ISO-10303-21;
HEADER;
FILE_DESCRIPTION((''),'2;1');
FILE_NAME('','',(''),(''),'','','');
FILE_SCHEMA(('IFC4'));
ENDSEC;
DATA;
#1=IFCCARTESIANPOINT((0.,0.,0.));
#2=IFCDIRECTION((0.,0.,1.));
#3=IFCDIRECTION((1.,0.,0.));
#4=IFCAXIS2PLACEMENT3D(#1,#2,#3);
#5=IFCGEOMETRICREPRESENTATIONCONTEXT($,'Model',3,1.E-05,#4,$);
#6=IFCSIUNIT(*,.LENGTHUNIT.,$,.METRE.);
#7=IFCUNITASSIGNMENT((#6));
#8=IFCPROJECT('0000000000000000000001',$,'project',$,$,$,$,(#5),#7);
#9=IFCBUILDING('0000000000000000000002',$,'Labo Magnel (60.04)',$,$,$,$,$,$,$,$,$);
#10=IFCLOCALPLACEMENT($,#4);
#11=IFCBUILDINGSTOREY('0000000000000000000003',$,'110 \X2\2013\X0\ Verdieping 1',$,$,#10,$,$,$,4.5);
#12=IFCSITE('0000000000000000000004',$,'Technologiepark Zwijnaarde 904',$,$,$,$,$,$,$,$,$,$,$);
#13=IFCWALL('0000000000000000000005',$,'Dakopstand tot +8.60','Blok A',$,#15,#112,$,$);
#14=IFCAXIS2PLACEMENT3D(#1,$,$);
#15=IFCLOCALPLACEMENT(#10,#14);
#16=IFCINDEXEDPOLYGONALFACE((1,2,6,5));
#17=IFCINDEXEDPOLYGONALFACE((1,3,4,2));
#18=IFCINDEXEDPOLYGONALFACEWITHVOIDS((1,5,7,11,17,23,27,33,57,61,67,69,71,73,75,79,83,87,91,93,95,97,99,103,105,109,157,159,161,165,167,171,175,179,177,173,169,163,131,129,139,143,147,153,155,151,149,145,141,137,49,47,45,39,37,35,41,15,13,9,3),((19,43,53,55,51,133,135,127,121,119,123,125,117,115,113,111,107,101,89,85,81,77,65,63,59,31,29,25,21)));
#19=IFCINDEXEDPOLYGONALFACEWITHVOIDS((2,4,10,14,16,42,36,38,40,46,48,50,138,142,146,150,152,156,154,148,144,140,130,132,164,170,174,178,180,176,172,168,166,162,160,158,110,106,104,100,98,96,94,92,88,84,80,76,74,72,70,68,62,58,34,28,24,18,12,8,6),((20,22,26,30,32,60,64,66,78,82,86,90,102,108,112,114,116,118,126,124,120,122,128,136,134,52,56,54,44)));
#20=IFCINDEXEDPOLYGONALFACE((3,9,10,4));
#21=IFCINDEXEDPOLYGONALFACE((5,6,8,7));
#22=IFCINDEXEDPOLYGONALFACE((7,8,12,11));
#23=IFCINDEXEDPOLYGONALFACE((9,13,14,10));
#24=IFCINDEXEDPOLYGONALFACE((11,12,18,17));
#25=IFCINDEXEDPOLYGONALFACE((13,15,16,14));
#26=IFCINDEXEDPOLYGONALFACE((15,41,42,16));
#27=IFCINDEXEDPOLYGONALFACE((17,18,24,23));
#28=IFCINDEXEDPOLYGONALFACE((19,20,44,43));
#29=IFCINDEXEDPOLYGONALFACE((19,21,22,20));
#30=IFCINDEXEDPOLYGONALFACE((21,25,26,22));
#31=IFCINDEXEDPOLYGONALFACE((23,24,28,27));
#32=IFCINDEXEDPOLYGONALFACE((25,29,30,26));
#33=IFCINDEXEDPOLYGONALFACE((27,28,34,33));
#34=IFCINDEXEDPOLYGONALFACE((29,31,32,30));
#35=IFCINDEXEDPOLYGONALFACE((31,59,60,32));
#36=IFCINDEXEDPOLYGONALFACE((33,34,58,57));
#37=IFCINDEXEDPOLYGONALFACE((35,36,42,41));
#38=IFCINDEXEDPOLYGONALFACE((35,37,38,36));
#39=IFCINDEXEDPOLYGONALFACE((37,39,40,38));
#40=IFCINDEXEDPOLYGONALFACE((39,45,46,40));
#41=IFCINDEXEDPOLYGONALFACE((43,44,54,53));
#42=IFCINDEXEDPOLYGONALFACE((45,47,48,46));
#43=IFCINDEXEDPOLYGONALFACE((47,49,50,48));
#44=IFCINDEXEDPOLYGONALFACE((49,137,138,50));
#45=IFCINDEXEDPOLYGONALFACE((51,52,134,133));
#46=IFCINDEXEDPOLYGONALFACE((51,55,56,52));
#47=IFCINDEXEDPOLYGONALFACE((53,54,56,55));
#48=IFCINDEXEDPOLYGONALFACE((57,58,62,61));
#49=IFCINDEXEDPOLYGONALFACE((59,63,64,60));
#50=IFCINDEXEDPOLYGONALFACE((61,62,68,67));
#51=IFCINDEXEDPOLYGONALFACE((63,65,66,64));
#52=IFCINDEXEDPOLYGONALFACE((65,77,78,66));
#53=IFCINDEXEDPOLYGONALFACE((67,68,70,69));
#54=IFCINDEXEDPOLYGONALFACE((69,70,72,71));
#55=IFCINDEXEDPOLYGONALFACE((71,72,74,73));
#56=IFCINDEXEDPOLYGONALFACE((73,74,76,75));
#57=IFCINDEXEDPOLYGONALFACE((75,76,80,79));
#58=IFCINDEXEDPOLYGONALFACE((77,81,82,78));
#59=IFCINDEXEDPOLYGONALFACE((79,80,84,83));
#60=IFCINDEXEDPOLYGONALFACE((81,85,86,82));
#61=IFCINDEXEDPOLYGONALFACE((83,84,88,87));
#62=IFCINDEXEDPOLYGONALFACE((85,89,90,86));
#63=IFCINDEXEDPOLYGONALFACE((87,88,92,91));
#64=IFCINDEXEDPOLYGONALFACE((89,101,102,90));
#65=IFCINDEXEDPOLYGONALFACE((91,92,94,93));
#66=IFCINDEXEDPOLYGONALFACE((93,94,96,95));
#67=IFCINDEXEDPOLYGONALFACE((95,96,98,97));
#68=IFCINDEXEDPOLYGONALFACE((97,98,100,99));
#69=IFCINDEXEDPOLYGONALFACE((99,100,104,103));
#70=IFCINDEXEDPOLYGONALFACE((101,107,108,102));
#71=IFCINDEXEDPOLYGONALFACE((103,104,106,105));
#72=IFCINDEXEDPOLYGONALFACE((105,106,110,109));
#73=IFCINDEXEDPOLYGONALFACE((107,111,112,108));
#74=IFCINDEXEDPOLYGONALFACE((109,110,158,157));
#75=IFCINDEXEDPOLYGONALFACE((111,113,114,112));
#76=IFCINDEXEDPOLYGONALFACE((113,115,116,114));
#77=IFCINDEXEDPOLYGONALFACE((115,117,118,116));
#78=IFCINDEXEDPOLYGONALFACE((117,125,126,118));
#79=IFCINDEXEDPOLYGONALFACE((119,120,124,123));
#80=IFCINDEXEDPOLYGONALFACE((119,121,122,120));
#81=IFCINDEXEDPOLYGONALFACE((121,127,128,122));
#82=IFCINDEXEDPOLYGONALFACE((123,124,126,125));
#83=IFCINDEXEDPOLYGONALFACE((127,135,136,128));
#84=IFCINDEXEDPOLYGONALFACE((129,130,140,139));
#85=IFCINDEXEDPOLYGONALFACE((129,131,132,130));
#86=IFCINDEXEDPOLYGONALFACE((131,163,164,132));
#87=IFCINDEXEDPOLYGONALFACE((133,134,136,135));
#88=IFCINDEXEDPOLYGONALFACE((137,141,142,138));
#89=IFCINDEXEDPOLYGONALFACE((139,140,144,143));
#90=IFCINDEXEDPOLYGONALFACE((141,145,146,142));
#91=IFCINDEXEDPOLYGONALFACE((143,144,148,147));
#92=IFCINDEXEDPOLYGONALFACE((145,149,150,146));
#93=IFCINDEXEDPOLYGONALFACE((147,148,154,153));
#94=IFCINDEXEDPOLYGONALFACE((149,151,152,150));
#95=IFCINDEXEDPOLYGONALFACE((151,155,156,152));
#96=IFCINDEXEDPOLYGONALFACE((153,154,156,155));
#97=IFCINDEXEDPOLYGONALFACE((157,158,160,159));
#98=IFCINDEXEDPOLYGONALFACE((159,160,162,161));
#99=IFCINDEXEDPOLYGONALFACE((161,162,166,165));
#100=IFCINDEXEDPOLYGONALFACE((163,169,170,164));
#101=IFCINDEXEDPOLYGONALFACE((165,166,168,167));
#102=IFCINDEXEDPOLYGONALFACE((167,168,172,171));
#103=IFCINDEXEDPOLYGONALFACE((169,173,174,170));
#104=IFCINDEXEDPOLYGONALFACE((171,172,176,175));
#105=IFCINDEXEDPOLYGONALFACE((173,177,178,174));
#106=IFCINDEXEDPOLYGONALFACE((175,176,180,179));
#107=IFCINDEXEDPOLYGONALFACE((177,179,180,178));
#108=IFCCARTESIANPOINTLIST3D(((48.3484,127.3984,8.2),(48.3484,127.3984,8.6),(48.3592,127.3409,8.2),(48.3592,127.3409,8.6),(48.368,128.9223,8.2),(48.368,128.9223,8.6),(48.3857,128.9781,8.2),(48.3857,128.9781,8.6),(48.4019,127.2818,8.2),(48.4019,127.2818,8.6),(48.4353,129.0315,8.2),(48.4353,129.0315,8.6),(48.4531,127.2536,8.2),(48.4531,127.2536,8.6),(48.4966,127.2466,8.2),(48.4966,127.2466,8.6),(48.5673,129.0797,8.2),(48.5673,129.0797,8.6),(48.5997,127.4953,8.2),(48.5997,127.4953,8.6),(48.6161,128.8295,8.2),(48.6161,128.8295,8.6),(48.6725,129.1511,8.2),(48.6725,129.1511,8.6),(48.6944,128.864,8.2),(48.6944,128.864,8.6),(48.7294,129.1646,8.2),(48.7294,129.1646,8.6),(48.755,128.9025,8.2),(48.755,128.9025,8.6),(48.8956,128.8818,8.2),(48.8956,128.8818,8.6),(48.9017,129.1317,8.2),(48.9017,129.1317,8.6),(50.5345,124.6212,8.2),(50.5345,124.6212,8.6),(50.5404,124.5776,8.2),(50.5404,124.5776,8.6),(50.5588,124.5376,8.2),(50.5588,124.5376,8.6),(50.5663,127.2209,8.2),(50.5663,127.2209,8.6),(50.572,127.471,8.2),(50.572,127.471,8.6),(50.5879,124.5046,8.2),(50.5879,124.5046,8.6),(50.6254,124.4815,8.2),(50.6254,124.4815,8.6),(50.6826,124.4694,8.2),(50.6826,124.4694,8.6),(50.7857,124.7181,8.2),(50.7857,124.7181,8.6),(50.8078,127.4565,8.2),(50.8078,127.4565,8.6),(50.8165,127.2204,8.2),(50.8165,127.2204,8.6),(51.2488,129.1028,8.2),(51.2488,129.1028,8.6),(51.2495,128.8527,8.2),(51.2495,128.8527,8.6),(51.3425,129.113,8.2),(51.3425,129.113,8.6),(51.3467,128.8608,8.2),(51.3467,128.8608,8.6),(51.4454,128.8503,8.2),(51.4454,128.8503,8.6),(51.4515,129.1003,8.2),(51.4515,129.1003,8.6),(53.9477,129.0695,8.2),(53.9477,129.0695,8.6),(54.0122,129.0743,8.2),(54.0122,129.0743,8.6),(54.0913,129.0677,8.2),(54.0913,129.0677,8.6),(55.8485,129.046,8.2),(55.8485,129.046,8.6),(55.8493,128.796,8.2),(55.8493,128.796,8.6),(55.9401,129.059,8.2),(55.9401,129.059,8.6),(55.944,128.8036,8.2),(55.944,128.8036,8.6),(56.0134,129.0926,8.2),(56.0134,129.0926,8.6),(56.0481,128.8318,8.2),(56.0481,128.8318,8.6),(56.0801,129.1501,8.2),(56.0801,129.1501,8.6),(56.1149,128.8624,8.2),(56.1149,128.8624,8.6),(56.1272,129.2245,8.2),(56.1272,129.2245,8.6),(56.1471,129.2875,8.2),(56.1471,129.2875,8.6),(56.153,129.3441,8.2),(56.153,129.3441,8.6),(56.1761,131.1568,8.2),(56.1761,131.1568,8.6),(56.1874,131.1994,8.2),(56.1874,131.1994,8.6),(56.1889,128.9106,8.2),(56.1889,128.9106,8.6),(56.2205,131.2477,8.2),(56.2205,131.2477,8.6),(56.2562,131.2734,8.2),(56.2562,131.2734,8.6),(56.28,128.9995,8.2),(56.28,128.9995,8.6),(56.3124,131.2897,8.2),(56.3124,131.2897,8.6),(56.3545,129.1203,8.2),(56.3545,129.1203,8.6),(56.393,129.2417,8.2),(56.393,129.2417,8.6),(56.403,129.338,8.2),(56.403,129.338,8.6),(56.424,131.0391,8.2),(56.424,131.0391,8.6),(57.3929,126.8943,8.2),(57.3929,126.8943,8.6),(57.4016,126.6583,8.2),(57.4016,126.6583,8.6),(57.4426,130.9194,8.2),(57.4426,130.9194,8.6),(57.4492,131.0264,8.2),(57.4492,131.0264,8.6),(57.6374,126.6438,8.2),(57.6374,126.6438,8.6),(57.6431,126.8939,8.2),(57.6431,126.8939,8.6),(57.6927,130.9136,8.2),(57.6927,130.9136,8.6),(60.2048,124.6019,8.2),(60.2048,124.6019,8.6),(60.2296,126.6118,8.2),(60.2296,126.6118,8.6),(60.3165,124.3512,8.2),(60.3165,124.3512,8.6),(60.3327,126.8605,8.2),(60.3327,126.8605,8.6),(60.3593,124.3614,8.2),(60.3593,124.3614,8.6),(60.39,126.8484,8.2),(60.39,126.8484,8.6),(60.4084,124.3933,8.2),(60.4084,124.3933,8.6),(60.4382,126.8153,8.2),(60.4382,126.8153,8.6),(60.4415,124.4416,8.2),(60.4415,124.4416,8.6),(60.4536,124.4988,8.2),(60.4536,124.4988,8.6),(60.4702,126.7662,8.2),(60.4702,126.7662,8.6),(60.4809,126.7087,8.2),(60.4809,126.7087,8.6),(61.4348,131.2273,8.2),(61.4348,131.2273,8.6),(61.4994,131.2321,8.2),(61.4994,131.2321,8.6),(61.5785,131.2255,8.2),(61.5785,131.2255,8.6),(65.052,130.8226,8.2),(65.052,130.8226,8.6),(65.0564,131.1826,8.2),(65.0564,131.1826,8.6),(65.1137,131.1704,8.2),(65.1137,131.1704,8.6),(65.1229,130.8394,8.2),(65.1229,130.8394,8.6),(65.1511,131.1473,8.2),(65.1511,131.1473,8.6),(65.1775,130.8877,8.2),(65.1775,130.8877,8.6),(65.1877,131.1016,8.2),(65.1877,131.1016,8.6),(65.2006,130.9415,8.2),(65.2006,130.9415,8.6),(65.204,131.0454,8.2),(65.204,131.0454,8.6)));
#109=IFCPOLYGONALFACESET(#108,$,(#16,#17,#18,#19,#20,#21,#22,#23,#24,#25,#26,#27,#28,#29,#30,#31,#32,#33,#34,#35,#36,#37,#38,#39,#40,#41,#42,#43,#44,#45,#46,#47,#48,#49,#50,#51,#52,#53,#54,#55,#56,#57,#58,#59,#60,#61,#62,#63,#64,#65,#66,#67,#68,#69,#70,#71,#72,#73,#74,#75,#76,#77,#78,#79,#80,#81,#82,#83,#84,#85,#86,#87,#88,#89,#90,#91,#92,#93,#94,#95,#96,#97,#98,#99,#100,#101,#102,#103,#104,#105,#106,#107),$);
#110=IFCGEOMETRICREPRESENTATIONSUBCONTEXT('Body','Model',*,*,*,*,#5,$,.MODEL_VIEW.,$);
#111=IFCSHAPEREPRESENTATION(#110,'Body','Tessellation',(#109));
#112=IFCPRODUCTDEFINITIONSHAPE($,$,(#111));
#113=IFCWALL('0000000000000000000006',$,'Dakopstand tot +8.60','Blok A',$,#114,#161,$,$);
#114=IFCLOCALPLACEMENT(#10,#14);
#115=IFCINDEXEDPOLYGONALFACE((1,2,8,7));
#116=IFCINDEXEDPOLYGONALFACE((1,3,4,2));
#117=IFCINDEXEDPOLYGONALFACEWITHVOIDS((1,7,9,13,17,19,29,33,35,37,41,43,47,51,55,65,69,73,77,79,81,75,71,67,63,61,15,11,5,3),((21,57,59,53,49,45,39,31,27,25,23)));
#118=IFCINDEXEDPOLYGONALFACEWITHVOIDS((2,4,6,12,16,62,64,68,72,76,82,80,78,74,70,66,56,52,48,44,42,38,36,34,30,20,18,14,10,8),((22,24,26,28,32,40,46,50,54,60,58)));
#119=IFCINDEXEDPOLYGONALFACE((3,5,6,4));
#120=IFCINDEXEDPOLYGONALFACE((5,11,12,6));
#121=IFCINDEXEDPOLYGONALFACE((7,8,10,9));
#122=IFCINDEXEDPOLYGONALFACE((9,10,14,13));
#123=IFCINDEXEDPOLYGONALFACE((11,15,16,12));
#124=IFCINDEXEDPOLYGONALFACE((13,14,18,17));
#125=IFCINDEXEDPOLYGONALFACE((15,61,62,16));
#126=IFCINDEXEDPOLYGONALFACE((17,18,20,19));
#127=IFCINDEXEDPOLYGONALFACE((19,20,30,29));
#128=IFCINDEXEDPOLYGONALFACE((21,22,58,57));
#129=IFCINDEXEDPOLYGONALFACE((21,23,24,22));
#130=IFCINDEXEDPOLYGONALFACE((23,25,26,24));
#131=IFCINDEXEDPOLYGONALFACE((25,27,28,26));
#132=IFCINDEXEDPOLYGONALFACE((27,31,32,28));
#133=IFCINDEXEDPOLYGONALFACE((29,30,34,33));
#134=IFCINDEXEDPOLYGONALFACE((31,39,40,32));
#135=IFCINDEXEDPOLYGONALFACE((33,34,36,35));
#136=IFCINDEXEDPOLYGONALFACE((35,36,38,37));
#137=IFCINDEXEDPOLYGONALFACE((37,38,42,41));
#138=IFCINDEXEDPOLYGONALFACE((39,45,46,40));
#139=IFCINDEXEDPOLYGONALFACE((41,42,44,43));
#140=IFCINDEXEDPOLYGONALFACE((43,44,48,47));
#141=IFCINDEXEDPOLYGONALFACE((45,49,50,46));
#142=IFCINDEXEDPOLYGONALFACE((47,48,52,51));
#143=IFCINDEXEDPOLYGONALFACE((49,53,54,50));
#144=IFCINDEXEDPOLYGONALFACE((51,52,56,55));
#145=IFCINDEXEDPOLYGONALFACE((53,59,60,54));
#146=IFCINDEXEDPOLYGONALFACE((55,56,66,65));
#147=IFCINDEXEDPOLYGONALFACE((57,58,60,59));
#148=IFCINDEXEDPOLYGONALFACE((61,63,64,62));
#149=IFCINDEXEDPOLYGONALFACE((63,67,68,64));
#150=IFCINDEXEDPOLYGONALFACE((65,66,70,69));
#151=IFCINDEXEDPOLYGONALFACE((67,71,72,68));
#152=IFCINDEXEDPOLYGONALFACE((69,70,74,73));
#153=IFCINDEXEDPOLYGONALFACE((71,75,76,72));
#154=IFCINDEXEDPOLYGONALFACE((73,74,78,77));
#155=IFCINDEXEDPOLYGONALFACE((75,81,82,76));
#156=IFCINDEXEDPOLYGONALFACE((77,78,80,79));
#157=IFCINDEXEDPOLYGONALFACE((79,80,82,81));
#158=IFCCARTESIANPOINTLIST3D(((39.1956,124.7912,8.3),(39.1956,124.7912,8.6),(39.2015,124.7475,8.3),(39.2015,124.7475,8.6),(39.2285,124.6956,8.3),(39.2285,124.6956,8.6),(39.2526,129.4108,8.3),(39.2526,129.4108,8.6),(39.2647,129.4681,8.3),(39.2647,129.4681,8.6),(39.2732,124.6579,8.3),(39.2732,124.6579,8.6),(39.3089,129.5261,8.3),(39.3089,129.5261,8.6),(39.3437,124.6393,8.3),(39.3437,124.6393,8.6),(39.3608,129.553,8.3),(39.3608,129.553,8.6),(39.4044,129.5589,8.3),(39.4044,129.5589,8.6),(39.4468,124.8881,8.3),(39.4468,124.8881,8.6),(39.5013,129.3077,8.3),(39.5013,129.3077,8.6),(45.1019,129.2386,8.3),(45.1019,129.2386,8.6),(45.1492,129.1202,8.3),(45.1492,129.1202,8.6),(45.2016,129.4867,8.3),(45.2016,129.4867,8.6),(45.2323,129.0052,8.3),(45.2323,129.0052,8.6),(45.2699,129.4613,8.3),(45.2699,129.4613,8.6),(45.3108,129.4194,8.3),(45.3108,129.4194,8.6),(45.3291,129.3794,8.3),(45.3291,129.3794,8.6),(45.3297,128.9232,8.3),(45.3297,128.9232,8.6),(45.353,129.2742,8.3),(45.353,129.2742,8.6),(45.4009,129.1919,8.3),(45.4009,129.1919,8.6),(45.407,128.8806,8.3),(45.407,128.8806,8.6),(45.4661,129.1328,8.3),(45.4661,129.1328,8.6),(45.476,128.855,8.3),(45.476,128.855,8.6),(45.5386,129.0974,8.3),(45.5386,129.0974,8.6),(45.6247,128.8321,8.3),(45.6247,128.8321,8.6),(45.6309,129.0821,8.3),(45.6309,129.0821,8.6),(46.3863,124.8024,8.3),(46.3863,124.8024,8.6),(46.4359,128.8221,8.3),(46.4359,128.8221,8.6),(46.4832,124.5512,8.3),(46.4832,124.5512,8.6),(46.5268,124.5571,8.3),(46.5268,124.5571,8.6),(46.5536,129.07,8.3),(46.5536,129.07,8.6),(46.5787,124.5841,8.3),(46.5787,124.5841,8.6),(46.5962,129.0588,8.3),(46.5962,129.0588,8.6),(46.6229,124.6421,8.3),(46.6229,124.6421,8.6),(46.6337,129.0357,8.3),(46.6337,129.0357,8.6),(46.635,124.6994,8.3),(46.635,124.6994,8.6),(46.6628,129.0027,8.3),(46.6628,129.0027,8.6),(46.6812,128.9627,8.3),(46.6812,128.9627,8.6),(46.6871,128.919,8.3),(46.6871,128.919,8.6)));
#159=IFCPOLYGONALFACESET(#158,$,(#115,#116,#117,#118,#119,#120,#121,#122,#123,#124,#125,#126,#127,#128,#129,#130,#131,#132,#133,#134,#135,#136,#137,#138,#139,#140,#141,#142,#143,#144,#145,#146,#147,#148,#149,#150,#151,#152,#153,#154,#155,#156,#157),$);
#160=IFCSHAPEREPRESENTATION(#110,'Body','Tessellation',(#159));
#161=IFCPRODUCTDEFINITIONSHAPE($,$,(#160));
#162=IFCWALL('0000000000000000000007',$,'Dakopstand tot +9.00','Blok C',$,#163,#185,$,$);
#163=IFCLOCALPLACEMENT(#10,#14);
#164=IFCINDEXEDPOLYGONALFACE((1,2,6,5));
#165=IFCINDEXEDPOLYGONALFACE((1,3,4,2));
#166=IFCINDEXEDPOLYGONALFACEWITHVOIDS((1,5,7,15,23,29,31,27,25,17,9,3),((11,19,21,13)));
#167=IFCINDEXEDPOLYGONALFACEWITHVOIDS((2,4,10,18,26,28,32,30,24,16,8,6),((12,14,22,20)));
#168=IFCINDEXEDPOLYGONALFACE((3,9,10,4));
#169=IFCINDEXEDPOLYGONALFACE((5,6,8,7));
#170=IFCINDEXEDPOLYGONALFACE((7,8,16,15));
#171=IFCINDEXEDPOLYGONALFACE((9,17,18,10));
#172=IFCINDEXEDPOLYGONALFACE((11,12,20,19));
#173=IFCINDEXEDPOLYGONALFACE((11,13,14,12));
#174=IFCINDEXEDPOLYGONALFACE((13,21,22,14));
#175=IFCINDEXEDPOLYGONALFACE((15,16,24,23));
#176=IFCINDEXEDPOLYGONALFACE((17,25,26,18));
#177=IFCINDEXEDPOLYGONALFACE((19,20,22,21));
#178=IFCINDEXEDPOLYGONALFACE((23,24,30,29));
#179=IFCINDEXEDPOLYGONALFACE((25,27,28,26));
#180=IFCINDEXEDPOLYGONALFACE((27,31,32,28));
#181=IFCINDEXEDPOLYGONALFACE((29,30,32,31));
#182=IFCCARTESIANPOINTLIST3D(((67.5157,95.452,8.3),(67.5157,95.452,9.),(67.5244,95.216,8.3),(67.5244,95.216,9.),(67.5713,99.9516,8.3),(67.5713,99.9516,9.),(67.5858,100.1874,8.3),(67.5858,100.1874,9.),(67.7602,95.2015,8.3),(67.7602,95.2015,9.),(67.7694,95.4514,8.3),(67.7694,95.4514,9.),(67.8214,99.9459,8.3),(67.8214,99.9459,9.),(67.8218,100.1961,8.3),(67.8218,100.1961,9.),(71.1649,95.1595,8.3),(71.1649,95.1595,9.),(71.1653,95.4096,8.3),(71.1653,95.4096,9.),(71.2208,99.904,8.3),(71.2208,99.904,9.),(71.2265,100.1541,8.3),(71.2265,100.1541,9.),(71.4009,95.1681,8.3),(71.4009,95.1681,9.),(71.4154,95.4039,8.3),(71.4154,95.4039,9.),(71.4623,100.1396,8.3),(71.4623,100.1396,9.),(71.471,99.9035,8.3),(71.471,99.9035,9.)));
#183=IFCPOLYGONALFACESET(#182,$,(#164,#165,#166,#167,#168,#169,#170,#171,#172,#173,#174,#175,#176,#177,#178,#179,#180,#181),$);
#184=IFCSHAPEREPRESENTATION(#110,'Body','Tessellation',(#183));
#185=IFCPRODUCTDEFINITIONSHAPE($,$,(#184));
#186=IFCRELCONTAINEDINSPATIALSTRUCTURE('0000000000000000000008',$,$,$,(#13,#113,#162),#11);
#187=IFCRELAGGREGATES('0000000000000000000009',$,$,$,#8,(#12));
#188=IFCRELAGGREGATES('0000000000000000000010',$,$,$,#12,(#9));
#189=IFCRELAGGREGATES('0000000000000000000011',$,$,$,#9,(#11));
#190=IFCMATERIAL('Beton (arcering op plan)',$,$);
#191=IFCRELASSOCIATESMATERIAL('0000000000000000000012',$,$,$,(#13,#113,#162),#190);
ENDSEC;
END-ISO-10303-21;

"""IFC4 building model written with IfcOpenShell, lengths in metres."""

from ifc_helpers import new_model, si_unit, frame, origin, origin_with_axes, place, context, subcontext, project, spatial, polyline, outline, extrude, material, element, save


model = new_model("IFC4")

# Units and contexts
model_context = context("Model", 3, precision=1e-05, world=origin_with_axes())
body_context = subcontext(model_context, "Body", "Model", "MODEL_VIEW")
ifc_project = project(units=[si_unit("LENGTHUNIT", "METRE")], contexts=[model_context])

# Site, building, storey
site = spatial("IfcSite", under=ifc_project, Name="Technologiepark Zwijnaarde 904")
building = spatial("IfcBuilding", under=site, Name="Labo Magnel (60.04)")
storey_placement = place(None, origin_with_axes())
storey = spatial("IfcBuildingStorey", under=building, at=storey_placement, Name="110 – Verdieping 1", Elevation=4.5)

# Shared definitions
ifc_material_1 = material(Name="Beton (arcering op plan)")

# Walls
wall_1_placement = place(storey_placement, frame((0.0, 0.0, 8.2), z_axis=(0.0, 0.0, 1.0), x_axis=(1.0, 0.0, 0.0)))
element("IfcWall", 1, at=wall_1_placement, inside=storey, material=ifc_material_1, Name="Dakopstand tot +8.60", Description="Blok A", context=body_context, shape_type="SweptSolid", body=[
    extrude(outline(polyline([(48.368, 128.9223), (48.3857, 128.9781), (48.4353, 129.0315), (48.5673, 129.0797), (48.6725, 129.1511), (48.7294, 129.1646), (48.9017, 129.1317), (51.2488, 129.1028), (51.3425, 129.113), (51.4515, 129.1003), (53.9477, 129.0695), (54.0122, 129.0743), (54.0913, 129.0677), (55.8485, 129.046), (55.9401, 129.059), (56.0134, 129.0926), (56.0801, 129.1501), (56.1272, 129.2245), (56.1471, 129.2875), (56.153, 129.3441), (56.1761, 131.1568), (56.1874, 131.1994), (56.2205, 131.2477), (56.2562, 131.2734), (56.3124, 131.2897), (61.4348, 131.2273), (61.4994, 131.2321), (61.5785, 131.2255), (65.0564, 131.1826), (65.1137, 131.1704), (65.1511, 131.1473), (65.1877, 131.1016), (65.204, 131.0454), (65.2006, 130.9415), (65.1775, 130.8877), (65.1229, 130.8394), (65.052, 130.8226), (57.6927, 130.9136), (57.6431, 126.8939), (60.3327, 126.8605), (60.39, 126.8484), (60.4382, 126.8153), (60.4702, 126.7662), (60.4809, 126.7087), (60.4536, 124.4988), (60.4415, 124.4416), (60.4084, 124.3933), (60.3593, 124.3614), (60.3165, 124.3512), (50.6826, 124.4694), (50.6254, 124.4815), (50.5879, 124.5046), (50.5588, 124.5376), (50.5404, 124.5776), (50.5345, 124.6212), (50.5663, 127.2209), (48.4966, 127.2466), (48.4531, 127.2536), (48.4019, 127.2818), (48.3592, 127.3409), (48.3484, 127.3984), (48.368, 128.9223)]), holes=[polyline([(48.5997, 127.4953), (50.572, 127.471), (50.8078, 127.4565), (50.8165, 127.2204), (50.7857, 124.7181), (60.2048, 124.6019), (60.2296, 126.6118), (57.6374, 126.6438), (57.4016, 126.6583), (57.3929, 126.8943), (57.4426, 130.9194), (57.4492, 131.0264), (56.424, 131.0391), (56.403, 129.338), (56.393, 129.2417), (56.3545, 129.1203), (56.28, 128.9995), (56.1889, 128.9106), (56.1149, 128.8624), (56.0481, 128.8318), (55.944, 128.8036), (55.8493, 128.796), (51.4454, 128.8503), (51.3467, 128.8608), (51.2495, 128.8527), (48.8956, 128.8818), (48.755, 128.9025), (48.6944, 128.864), (48.6161, 128.8295), (48.5997, 127.4953)])]), origin(), (0.0, 0.0, 1.0), 0.4),
])
wall_2_placement = place(storey_placement, frame((0.0, 0.0, 8.3), z_axis=(0.0, 0.0, 1.0), x_axis=(1.0, 0.0, 0.0)))
element("IfcWall", 2, at=wall_2_placement, inside=storey, material=ifc_material_1, Name="Dakopstand tot +8.60", Description="Blok A", context=body_context, shape_type="SweptSolid", body=[
    extrude(outline(polyline([(45.2016, 129.4867), (45.2699, 129.4613), (45.3108, 129.4194), (45.3291, 129.3794), (45.353, 129.2742), (45.4009, 129.1919), (45.4661, 129.1328), (45.5386, 129.0974), (45.6309, 129.0821), (46.5536, 129.07), (46.5962, 129.0588), (46.6337, 129.0357), (46.6628, 129.0027), (46.6812, 128.9627), (46.6871, 128.919), (46.635, 124.6994), (46.6229, 124.6421), (46.5787, 124.5841), (46.5268, 124.5571), (46.4832, 124.5512), (39.3437, 124.6393), (39.2732, 124.6579), (39.2285, 124.6956), (39.2015, 124.7475), (39.1956, 124.7912), (39.2526, 129.4108), (39.2647, 129.4681), (39.3089, 129.5261), (39.3608, 129.553), (39.4044, 129.5589), (45.2016, 129.4867)]), holes=[polyline([(46.3863, 124.8024), (46.4359, 128.8221), (45.6247, 128.8321), (45.476, 128.855), (45.407, 128.8806), (45.3297, 128.9232), (45.2323, 129.0052), (45.1492, 129.1202), (45.1019, 129.2386), (39.5013, 129.3077), (39.4468, 124.8881), (46.3863, 124.8024)])]), origin(), (0.0, 0.0, 1.0), 0.3),
])
wall_3_placement = place(storey_placement, frame((0.0, 0.0, 8.3), z_axis=(0.0, 0.0, 1.0), x_axis=(1.0, 0.0, 0.0)))
element("IfcWall", 3, at=wall_3_placement, inside=storey, material=ifc_material_1, Name="Dakopstand tot +9.00", Description="Blok C", context=body_context, shape_type="SweptSolid", body=[
    extrude(outline(polyline([(67.5157, 95.452), (67.5713, 99.9516), (67.5858, 100.1874), (67.8218, 100.1961), (71.2265, 100.1541), (71.4623, 100.1396), (71.471, 99.9035), (71.4154, 95.4039), (71.4009, 95.1681), (71.1649, 95.1595), (67.7602, 95.2015), (67.5244, 95.216), (67.5157, 95.452)]), holes=[polyline([(67.7694, 95.4514), (71.1653, 95.4096), (71.2208, 99.904), (67.8214, 99.9459), (67.7694, 95.4514)])]), origin(), (0.0, 0.0, 1.0), 0.7),
])

save(model, "model.ifc")
